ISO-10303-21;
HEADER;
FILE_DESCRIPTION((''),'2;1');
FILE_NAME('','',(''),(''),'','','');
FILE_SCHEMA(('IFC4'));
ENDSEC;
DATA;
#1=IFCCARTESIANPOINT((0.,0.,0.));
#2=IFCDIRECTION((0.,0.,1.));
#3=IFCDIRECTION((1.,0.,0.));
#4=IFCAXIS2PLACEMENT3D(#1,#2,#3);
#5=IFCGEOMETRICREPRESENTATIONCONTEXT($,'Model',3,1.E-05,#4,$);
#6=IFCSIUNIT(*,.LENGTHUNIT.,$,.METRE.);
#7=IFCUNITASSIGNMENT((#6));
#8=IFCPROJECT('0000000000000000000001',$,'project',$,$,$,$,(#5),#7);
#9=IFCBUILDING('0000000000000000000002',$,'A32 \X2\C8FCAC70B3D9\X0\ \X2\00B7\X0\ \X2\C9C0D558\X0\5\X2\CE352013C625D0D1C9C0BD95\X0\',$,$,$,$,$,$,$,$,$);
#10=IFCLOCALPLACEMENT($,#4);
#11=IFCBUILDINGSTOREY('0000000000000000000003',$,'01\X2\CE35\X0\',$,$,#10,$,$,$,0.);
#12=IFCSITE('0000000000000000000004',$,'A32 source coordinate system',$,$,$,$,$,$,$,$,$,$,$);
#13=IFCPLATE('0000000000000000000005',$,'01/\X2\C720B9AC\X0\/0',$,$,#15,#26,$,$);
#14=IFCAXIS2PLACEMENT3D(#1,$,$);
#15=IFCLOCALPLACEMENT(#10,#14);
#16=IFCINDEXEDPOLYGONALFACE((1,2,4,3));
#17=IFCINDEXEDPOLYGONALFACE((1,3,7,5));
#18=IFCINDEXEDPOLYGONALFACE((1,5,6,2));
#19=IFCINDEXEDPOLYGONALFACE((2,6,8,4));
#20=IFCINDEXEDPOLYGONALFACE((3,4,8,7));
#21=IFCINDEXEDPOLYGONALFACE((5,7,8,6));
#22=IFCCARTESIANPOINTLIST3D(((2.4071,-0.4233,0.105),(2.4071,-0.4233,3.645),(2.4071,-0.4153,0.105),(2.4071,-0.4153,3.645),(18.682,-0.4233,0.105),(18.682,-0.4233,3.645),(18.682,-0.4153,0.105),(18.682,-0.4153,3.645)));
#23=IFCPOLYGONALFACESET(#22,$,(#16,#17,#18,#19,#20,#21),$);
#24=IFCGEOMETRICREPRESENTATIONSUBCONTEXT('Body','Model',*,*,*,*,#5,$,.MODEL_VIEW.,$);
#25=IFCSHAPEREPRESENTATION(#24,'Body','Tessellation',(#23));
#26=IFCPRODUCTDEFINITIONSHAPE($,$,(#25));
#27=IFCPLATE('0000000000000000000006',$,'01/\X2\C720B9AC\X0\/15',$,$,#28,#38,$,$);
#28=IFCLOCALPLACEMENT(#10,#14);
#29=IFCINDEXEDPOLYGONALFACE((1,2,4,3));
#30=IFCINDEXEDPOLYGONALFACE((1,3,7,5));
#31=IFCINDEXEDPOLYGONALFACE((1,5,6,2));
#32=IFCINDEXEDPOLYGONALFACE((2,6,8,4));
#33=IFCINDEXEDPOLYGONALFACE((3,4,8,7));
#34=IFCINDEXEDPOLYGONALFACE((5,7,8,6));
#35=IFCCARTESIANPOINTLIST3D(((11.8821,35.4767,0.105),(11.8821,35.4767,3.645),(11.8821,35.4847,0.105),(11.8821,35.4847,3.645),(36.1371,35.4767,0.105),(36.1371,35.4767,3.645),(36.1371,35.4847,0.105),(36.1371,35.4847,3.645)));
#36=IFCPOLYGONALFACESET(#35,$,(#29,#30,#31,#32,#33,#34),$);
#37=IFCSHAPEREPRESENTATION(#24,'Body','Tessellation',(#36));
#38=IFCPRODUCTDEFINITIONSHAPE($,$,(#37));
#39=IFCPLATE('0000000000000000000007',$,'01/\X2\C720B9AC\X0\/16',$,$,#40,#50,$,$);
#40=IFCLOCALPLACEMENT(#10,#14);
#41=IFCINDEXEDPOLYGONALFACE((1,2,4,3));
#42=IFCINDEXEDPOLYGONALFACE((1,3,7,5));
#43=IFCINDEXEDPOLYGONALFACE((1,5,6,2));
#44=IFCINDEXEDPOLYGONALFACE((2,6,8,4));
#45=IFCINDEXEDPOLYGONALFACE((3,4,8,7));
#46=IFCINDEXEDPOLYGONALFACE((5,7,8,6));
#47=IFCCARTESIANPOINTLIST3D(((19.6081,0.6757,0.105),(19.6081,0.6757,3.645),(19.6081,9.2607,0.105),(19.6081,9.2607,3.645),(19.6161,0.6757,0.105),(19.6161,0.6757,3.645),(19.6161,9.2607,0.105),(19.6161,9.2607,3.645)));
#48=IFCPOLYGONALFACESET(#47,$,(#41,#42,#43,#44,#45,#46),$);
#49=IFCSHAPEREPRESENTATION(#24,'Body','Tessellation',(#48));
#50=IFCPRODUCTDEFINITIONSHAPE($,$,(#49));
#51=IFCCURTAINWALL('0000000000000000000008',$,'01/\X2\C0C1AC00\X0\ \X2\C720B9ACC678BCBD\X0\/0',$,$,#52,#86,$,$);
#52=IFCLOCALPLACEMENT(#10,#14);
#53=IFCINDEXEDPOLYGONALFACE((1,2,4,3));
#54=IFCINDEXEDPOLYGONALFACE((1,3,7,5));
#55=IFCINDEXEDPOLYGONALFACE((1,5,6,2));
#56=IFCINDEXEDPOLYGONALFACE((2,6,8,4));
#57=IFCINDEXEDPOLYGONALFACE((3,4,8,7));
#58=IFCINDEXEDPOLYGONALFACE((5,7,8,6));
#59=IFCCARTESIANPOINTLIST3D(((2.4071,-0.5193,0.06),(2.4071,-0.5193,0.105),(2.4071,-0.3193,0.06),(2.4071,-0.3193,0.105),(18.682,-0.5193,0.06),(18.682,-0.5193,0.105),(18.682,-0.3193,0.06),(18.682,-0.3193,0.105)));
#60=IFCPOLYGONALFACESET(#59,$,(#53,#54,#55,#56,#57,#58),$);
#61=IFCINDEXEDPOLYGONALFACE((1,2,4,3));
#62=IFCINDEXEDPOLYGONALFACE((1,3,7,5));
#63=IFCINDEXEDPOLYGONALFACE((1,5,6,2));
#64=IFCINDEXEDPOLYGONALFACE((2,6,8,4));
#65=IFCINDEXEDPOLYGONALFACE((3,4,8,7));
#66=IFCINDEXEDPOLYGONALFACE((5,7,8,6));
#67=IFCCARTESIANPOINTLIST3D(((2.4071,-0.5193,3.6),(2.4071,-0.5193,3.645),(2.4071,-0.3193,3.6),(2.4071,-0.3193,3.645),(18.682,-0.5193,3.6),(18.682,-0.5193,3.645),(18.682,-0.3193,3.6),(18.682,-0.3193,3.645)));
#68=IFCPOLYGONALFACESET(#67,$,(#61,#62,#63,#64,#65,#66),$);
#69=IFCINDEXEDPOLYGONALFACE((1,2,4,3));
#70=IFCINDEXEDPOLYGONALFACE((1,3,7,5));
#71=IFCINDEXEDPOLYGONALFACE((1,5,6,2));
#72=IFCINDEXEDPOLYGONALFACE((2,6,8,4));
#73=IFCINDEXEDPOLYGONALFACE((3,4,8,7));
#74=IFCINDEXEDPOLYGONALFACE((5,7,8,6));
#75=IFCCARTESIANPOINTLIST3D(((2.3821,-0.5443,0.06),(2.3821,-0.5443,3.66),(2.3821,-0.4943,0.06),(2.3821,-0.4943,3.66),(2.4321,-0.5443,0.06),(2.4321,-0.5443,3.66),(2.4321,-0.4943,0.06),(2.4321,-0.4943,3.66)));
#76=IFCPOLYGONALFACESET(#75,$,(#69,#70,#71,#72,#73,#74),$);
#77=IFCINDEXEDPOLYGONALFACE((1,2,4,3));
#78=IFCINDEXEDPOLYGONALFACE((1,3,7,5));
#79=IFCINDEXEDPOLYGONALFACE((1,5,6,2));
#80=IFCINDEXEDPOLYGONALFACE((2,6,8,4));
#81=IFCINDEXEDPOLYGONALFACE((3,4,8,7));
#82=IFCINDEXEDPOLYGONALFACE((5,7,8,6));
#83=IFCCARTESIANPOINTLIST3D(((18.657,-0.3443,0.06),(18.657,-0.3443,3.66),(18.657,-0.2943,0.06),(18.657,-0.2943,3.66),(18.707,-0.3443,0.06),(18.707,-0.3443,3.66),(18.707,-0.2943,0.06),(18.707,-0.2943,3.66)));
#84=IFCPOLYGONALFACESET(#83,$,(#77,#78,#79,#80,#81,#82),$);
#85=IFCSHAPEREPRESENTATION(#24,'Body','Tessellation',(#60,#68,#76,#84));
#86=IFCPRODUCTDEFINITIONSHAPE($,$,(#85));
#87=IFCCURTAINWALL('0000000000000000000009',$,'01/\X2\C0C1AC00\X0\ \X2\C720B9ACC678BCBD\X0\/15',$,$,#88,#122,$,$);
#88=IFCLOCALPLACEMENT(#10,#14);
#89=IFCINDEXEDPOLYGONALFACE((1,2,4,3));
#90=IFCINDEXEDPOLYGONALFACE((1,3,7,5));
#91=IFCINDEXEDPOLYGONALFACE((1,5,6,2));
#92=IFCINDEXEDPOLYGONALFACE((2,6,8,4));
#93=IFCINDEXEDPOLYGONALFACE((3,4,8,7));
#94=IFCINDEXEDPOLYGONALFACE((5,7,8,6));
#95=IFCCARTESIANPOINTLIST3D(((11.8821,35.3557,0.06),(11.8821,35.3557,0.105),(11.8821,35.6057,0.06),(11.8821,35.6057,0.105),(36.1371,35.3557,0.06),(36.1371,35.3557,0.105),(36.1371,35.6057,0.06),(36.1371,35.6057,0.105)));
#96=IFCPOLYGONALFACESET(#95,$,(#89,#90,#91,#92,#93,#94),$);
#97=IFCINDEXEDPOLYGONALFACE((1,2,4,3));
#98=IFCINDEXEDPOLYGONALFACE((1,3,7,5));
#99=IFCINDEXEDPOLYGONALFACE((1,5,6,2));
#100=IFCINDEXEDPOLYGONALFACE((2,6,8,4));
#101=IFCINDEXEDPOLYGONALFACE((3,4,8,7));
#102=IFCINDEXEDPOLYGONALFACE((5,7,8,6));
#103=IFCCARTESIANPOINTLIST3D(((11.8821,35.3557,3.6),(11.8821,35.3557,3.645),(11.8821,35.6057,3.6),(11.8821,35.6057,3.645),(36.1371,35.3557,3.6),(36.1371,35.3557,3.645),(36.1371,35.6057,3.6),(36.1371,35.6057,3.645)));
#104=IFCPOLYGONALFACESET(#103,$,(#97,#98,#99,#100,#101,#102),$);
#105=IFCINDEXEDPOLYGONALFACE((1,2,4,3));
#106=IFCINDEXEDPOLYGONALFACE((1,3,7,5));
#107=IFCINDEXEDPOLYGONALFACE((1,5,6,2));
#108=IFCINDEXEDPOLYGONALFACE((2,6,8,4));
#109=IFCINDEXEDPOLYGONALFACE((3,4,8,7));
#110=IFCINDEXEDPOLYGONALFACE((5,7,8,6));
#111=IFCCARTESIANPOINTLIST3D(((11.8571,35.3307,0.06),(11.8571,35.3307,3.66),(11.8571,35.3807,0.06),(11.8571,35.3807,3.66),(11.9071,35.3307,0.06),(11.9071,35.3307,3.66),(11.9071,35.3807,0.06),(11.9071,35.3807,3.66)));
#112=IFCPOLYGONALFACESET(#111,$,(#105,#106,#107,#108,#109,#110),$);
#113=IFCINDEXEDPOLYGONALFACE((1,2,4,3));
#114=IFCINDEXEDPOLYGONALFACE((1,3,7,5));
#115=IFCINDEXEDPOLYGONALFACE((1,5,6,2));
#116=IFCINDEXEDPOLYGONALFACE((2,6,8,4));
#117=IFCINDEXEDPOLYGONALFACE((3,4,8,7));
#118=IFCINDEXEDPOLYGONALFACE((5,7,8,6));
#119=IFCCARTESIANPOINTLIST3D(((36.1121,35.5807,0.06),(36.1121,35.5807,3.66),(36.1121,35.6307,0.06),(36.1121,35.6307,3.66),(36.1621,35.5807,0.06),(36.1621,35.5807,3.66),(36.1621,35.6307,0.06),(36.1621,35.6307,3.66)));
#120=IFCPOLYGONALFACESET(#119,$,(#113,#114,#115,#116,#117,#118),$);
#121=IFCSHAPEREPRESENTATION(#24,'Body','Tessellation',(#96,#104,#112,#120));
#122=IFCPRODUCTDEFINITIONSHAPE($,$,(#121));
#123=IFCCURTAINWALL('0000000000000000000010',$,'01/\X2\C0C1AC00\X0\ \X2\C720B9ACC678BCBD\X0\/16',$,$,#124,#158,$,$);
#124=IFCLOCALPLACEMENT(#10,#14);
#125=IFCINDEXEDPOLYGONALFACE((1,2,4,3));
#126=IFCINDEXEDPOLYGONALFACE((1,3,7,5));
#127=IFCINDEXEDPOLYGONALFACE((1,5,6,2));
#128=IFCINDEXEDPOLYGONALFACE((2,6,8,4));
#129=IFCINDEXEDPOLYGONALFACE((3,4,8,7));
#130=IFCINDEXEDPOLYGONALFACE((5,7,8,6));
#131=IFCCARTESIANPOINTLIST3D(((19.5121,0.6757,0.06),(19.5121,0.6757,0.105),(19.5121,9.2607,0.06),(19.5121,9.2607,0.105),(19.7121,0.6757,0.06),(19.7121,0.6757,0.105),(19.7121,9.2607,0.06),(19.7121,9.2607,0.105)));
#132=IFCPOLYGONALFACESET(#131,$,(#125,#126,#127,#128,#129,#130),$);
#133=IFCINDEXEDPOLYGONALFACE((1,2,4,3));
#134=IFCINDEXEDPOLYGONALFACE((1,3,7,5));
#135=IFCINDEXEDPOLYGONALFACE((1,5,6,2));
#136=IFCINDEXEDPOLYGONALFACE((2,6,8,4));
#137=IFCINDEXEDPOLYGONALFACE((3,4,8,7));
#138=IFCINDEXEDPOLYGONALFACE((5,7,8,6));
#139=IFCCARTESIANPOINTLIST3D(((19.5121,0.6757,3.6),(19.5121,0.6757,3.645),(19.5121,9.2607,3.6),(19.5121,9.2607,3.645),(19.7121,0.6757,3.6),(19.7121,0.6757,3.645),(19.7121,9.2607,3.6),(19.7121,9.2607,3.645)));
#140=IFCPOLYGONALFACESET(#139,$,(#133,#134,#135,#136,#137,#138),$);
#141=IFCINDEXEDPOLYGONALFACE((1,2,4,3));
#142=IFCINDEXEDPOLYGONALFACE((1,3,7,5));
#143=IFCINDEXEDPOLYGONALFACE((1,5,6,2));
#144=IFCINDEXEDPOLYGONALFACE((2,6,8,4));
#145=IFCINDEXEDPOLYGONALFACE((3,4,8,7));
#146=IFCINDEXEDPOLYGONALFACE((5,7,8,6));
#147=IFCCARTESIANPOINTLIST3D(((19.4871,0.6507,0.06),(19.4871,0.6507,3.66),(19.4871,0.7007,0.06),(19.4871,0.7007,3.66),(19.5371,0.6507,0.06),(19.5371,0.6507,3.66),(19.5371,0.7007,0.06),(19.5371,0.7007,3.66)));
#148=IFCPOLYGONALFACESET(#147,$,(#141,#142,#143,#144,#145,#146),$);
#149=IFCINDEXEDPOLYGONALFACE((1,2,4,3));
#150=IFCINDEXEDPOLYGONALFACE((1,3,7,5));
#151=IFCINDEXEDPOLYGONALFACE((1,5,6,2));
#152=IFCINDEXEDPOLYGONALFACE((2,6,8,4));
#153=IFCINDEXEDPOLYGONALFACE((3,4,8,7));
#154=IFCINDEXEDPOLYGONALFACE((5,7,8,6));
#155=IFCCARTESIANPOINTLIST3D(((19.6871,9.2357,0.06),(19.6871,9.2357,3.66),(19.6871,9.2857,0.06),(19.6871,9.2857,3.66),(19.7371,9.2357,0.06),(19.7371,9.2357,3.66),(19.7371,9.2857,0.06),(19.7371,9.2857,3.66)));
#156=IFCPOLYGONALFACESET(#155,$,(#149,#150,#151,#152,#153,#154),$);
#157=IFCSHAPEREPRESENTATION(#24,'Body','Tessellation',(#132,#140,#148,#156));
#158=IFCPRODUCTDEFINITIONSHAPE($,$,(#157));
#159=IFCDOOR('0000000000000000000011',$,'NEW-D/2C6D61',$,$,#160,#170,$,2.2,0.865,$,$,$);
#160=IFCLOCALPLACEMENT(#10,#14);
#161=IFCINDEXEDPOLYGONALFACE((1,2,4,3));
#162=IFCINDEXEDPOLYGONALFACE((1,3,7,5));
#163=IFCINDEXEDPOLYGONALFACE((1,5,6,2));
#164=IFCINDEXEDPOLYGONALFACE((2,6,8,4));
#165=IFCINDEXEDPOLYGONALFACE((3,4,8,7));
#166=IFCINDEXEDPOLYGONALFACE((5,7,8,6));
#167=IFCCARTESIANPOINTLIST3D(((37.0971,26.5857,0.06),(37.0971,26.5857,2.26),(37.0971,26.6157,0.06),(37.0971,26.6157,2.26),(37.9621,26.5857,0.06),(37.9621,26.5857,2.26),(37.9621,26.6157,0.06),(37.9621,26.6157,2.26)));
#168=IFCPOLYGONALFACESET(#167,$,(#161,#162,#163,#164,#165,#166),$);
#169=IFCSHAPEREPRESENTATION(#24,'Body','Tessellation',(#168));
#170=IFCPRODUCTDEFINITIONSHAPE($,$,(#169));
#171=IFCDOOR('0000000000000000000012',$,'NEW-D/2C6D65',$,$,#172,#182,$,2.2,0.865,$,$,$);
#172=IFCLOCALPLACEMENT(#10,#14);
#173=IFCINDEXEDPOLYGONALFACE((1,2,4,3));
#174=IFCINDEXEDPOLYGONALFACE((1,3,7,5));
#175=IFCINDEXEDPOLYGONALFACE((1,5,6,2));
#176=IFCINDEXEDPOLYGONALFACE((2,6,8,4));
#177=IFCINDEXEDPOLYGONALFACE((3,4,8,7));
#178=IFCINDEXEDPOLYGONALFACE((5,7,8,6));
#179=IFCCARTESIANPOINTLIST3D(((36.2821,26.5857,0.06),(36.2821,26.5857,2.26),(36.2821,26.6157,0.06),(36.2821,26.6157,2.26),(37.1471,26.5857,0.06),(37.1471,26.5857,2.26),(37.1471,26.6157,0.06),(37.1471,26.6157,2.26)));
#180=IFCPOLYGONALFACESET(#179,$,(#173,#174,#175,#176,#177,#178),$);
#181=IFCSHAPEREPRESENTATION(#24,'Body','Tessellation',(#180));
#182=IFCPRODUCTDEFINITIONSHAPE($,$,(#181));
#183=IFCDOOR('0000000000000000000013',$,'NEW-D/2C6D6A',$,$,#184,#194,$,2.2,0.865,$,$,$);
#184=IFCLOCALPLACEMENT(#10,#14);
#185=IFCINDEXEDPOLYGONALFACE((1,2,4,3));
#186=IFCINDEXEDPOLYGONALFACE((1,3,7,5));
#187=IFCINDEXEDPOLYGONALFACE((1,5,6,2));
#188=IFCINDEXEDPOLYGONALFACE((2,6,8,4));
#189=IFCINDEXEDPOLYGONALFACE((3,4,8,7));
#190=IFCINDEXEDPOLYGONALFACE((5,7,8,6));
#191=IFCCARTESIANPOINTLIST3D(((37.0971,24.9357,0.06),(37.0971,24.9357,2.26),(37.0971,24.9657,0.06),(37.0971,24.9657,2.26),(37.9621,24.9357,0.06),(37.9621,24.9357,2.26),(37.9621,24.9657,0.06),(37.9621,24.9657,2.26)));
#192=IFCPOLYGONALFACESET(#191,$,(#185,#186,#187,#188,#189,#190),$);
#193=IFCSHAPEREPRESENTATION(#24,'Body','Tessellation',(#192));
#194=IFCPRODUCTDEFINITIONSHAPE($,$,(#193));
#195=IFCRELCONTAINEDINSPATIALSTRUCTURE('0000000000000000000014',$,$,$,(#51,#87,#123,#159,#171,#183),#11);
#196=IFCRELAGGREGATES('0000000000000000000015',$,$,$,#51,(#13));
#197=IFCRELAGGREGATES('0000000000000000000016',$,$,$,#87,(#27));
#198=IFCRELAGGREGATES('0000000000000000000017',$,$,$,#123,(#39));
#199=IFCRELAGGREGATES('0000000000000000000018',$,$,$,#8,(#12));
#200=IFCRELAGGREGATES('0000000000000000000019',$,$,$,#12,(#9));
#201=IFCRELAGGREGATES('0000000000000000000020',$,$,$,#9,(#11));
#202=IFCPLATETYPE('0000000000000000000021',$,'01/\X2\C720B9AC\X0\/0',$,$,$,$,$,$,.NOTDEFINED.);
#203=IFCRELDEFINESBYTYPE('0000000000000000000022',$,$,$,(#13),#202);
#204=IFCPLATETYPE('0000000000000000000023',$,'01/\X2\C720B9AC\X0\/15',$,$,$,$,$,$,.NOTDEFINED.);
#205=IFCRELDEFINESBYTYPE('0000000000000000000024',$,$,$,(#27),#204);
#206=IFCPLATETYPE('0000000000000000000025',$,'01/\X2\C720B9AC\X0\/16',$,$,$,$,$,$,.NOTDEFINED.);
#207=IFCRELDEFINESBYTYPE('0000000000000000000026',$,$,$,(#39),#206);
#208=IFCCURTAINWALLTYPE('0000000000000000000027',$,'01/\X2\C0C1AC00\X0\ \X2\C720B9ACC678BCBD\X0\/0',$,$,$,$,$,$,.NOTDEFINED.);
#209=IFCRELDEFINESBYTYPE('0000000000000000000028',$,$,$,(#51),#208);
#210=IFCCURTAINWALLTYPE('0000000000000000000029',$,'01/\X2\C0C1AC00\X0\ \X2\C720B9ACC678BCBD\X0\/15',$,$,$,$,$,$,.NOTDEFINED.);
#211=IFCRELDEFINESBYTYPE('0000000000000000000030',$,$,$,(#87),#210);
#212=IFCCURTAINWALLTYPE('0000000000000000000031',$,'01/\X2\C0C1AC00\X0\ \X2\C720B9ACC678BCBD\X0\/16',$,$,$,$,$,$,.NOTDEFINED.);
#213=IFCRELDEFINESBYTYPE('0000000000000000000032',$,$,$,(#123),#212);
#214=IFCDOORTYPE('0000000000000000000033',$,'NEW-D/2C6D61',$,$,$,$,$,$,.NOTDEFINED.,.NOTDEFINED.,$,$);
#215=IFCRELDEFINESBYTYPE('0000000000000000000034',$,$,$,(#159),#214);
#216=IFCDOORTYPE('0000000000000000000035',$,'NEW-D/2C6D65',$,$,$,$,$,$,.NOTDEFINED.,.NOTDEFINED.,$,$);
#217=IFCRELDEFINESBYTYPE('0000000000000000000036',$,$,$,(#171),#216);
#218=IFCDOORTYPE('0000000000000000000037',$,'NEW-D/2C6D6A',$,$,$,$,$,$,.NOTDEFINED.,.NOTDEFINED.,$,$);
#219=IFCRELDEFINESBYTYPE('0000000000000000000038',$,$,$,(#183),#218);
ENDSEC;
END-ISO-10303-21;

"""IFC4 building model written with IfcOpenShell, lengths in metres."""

from ifc_helpers import new_model, si_unit, frame, origin, origin_with_axes, place, context, subcontext, project, spatial, polyline, outline, extrude, source, transform, mapped, type_object, type_shapes, element, aggregate, save


model = new_model("IFC4")

# Units and contexts
model_context = context("Model", 3, precision=1e-05, world=origin_with_axes())
body_context = subcontext(model_context, "Body", "Model", "MODEL_VIEW")
ifc_project = project(units=[si_unit("LENGTHUNIT", "METRE")], contexts=[model_context])

# Plates
plate_type_1 = type_object("IfcPlateType", Name="01/유리/0", PredefinedType="NOTDEFINED")
shared_shape_1 = source(origin(), body_context, "Body", "SweptSolid", [
    extrude(outline(polyline([(18.682, -0.4233), (2.4071, -0.4233), (2.4071, -0.4153), (18.682, -0.4153), (18.682, -0.4233)])), frame((0.0, 0.0, 0.105)), (0.0, 0.0, 1.0), 3.54),
])
type_shapes(plate_type_1, [shared_shape_1])
storey_placement = place(None, origin_with_axes())
curtain_wall_1_placement = place(storey_placement, origin_with_axes())
plate_1_placement = place(curtain_wall_1_placement, origin_with_axes())
plate_1 = element("IfcPlate", 1, at=plate_1_placement, type_object=plate_type_1, Name="01/유리/0", context=body_context, shape_type="MappedRepresentation", body=[
    mapped(shared_shape_1, transform((0.0, 0.0, 0.0), scale=1.0)),
])
plate_type_2 = type_object("IfcPlateType", Name="01/유리/15", PredefinedType="NOTDEFINED")
shared_shape_2 = source(origin(), body_context, "Body", "SweptSolid", [
    extrude(outline(polyline([(36.1371, 35.4767), (11.8821, 35.4767), (11.8821, 35.4847), (36.1371, 35.4847), (36.1371, 35.4767)])), frame((0.0, 0.0, 0.105)), (0.0, 0.0, 1.0), 3.54),
])
type_shapes(plate_type_2, [shared_shape_2])
curtain_wall_2_placement = place(storey_placement, origin_with_axes())
plate_2_placement = place(curtain_wall_2_placement, origin_with_axes())
plate_2 = element("IfcPlate", 2, at=plate_2_placement, type_object=plate_type_2, Name="01/유리/15", context=body_context, shape_type="MappedRepresentation", body=[
    mapped(shared_shape_2, transform((0.0, 0.0, 0.0), scale=1.0)),
])
plate_type_3 = type_object("IfcPlateType", Name="01/유리/16", PredefinedType="NOTDEFINED")
shared_shape_3 = source(origin(), body_context, "Body", "SweptSolid", [
    extrude(outline(polyline([(19.6161, 0.6757), (19.6081, 0.6757), (19.6081, 9.2607), (19.6161, 9.2607), (19.6161, 0.6757)])), frame((0.0, 0.0, 0.105)), (0.0, 0.0, 1.0), 3.54),
])
type_shapes(plate_type_3, [shared_shape_3])
curtain_wall_3_placement = place(storey_placement, origin_with_axes())
plate_3_placement = place(curtain_wall_3_placement, origin_with_axes())
plate_3 = element("IfcPlate", 3, at=plate_3_placement, type_object=plate_type_3, Name="01/유리/16", context=body_context, shape_type="MappedRepresentation", body=[
    mapped(shared_shape_3, transform((0.0, 0.0, 0.0), scale=1.0)),
])

# Site, building, storey
site = spatial("IfcSite", under=ifc_project, Name="A32 source coordinate system")
building = spatial("IfcBuilding", under=site, Name="A32 주거동 · 지하5층–옥탑지붕")
storey = spatial("IfcBuildingStorey", under=building, at=storey_placement, Name="01층", Elevation=0.0)

# Curtain walls
curtain_wall_type_1 = type_object("IfcCurtainWallType", Name="01/상가 유리외벽/0", PredefinedType="NOTDEFINED")
shared_shape_4 = source(origin(), body_context, "Body", "SweptSolid", [
    extrude(outline(polyline([(18.682, -0.5193), (2.4071, -0.5193), (2.4071, -0.3193), (18.682, -0.3193), (18.682, -0.5193)])), frame((0.0, 0.0, 0.06)), (0.0, 0.0, 1.0), 0.045),
    extrude(outline(polyline([(18.682, -0.5193), (18.682, -0.3193), (2.4071, -0.3193), (2.4071, -0.5193), (18.682, -0.5193)])), frame((0.0, 0.0, 3.6)), (0.0, 0.0, 1.0), 0.045),
    extrude(outline(polyline([(2.4321, -0.5443), (2.4321, -0.4943), (2.3821, -0.4943), (2.3821, -0.5443), (2.4321, -0.5443)])), frame((0.0, 0.0, 0.06)), (0.0, 0.0, 1.0), 3.6),
    extrude(outline(polyline([(18.707, -0.3443), (18.707, -0.2943), (18.657, -0.2943), (18.657, -0.3443), (18.707, -0.3443)])), frame((0.0, 0.0, 0.06)), (0.0, 0.0, 1.0), 3.6),
])
type_shapes(curtain_wall_type_1, [shared_shape_4])
curtain_wall_1 = element("IfcCurtainWall", 4, at=curtain_wall_1_placement, inside=storey, type_object=curtain_wall_type_1, Name="01/상가 유리외벽/0", context=body_context, shape_type="MappedRepresentation", body=[
    mapped(shared_shape_4, transform((0.0, 0.0, 0.0), scale=1.0)),
])
aggregate(curtain_wall_1, [plate_1])
curtain_wall_type_2 = type_object("IfcCurtainWallType", Name="01/상가 유리외벽/15", PredefinedType="NOTDEFINED")
shared_shape_5 = source(origin(), body_context, "Body", "SweptSolid", [
    extrude(outline(polyline([(36.1371, 35.3557), (11.8821, 35.3557), (11.8821, 35.6057), (36.1371, 35.6057), (36.1371, 35.3557)])), frame((0.0, 0.0, 0.06)), (0.0, 0.0, 1.0), 0.045),
    extrude(outline(polyline([(36.1371, 35.3557), (36.1371, 35.6057), (11.8821, 35.6057), (11.8821, 35.3557), (36.1371, 35.3557)])), frame((0.0, 0.0, 3.6)), (0.0, 0.0, 1.0), 0.045),
    extrude(outline(polyline([(11.9071, 35.3307), (11.9071, 35.3807), (11.8571, 35.3807), (11.8571, 35.3307), (11.9071, 35.3307)])), frame((0.0, 0.0, 0.06)), (0.0, 0.0, 1.0), 3.6),
    extrude(outline(polyline([(36.1621, 35.5807), (36.1621, 35.6307), (36.1121, 35.6307), (36.1121, 35.5807), (36.1621, 35.5807)])), frame((0.0, 0.0, 0.06)), (0.0, 0.0, 1.0), 3.6),
])
type_shapes(curtain_wall_type_2, [shared_shape_5])
curtain_wall_2 = element("IfcCurtainWall", 5, at=curtain_wall_2_placement, inside=storey, type_object=curtain_wall_type_2, Name="01/상가 유리외벽/15", context=body_context, shape_type="MappedRepresentation", body=[
    mapped(shared_shape_5, transform((0.0, 0.0, 0.0), scale=1.0)),
])
aggregate(curtain_wall_2, [plate_2])
curtain_wall_type_3 = type_object("IfcCurtainWallType", Name="01/상가 유리외벽/16", PredefinedType="NOTDEFINED")
shared_shape_6 = source(origin(), body_context, "Body", "SweptSolid", [
    extrude(outline(polyline([(19.7121, 0.6757), (19.5121, 0.6757), (19.5121, 9.2607), (19.7121, 9.2607), (19.7121, 0.6757)])), frame((0.0, 0.0, 0.06)), (0.0, 0.0, 1.0), 0.045),
    extrude(outline(polyline([(19.7121, 0.6757), (19.7121, 9.2607), (19.5121, 9.2607), (19.5121, 0.6757), (19.7121, 0.6757)])), frame((0.0, 0.0, 3.6)), (0.0, 0.0, 1.0), 0.045),
    extrude(outline(polyline([(19.5371, 0.6507), (19.5371, 0.7007), (19.4871, 0.7007), (19.4871, 0.6507), (19.5371, 0.6507)])), frame((0.0, 0.0, 0.06)), (0.0, 0.0, 1.0), 3.6),
    extrude(outline(polyline([(19.7371, 9.2357), (19.7371, 9.2857), (19.6871, 9.2857), (19.6871, 9.2357), (19.7371, 9.2357)])), frame((0.0, 0.0, 0.06)), (0.0, 0.0, 1.0), 3.6),
])
type_shapes(curtain_wall_type_3, [shared_shape_6])
curtain_wall_3 = element("IfcCurtainWall", 6, at=curtain_wall_3_placement, inside=storey, type_object=curtain_wall_type_3, Name="01/상가 유리외벽/16", context=body_context, shape_type="MappedRepresentation", body=[
    mapped(shared_shape_6, transform((0.0, 0.0, 0.0), scale=1.0)),
])
aggregate(curtain_wall_3, [plate_3])

# Doors
door_type_1 = type_object("IfcDoorType", Name="NEW-D/2C6D61", OperationType="NOTDEFINED", PredefinedType="NOTDEFINED")
shared_shape_7 = source(origin(), body_context, "Body", "SweptSolid", [
    extrude(outline(polyline([(37.9621, 26.6157), (37.9621, 26.5857), (37.0971, 26.5857), (37.0971, 26.6157), (37.9621, 26.6157)])), frame((0.0, 0.0, 0.06)), (0.0, 0.0, 1.0), 2.2),
])
type_shapes(door_type_1, [shared_shape_7])
door_1_placement = place(storey_placement, origin_with_axes())
element("IfcDoor", 7, at=door_1_placement, inside=storey, type_object=door_type_1, Name="NEW-D/2C6D61", OverallHeight=2.2, OverallWidth=0.865, context=body_context, shape_type="MappedRepresentation", body=[
    mapped(shared_shape_7, transform((0.0, 0.0, 0.0), scale=1.0)),
])
door_type_2 = type_object("IfcDoorType", Name="NEW-D/2C6D65", OperationType="NOTDEFINED", PredefinedType="NOTDEFINED")
shared_shape_8 = source(origin(), body_context, "Body", "SweptSolid", [
    extrude(outline(polyline([(37.1471, 26.5857), (36.2821, 26.5857), (36.2821, 26.6157), (37.1471, 26.6157), (37.1471, 26.5857)])), frame((0.0, 0.0, 0.06)), (0.0, 0.0, 1.0), 2.2),
])
type_shapes(door_type_2, [shared_shape_8])
door_2_placement = place(storey_placement, origin_with_axes())
element("IfcDoor", 8, at=door_2_placement, inside=storey, type_object=door_type_2, Name="NEW-D/2C6D65", OverallHeight=2.2, OverallWidth=0.865, context=body_context, shape_type="MappedRepresentation", body=[
    mapped(shared_shape_8, transform((0.0, 0.0, 0.0), scale=1.0)),
])
door_type_3 = type_object("IfcDoorType", Name="NEW-D/2C6D6A", OperationType="NOTDEFINED", PredefinedType="NOTDEFINED")
shared_shape_9 = source(origin(), body_context, "Body", "SweptSolid", [
    extrude(outline(polyline([(37.0971, 24.9657), (37.9621, 24.9657), (37.9621, 24.9357), (37.0971, 24.9357), (37.0971, 24.9657)])), frame((0.0, 0.0, 0.06)), (0.0, 0.0, 1.0), 2.2),
])
type_shapes(door_type_3, [shared_shape_9])
door_3_placement = place(storey_placement, origin_with_axes())
element("IfcDoor", 9, at=door_3_placement, inside=storey, type_object=door_type_3, Name="NEW-D/2C6D6A", OverallHeight=2.2, OverallWidth=0.865, context=body_context, shape_type="MappedRepresentation", body=[
    mapped(shared_shape_9, transform((0.0, 0.0, 0.0), scale=1.0)),
])

save(model, "model.ifc")
